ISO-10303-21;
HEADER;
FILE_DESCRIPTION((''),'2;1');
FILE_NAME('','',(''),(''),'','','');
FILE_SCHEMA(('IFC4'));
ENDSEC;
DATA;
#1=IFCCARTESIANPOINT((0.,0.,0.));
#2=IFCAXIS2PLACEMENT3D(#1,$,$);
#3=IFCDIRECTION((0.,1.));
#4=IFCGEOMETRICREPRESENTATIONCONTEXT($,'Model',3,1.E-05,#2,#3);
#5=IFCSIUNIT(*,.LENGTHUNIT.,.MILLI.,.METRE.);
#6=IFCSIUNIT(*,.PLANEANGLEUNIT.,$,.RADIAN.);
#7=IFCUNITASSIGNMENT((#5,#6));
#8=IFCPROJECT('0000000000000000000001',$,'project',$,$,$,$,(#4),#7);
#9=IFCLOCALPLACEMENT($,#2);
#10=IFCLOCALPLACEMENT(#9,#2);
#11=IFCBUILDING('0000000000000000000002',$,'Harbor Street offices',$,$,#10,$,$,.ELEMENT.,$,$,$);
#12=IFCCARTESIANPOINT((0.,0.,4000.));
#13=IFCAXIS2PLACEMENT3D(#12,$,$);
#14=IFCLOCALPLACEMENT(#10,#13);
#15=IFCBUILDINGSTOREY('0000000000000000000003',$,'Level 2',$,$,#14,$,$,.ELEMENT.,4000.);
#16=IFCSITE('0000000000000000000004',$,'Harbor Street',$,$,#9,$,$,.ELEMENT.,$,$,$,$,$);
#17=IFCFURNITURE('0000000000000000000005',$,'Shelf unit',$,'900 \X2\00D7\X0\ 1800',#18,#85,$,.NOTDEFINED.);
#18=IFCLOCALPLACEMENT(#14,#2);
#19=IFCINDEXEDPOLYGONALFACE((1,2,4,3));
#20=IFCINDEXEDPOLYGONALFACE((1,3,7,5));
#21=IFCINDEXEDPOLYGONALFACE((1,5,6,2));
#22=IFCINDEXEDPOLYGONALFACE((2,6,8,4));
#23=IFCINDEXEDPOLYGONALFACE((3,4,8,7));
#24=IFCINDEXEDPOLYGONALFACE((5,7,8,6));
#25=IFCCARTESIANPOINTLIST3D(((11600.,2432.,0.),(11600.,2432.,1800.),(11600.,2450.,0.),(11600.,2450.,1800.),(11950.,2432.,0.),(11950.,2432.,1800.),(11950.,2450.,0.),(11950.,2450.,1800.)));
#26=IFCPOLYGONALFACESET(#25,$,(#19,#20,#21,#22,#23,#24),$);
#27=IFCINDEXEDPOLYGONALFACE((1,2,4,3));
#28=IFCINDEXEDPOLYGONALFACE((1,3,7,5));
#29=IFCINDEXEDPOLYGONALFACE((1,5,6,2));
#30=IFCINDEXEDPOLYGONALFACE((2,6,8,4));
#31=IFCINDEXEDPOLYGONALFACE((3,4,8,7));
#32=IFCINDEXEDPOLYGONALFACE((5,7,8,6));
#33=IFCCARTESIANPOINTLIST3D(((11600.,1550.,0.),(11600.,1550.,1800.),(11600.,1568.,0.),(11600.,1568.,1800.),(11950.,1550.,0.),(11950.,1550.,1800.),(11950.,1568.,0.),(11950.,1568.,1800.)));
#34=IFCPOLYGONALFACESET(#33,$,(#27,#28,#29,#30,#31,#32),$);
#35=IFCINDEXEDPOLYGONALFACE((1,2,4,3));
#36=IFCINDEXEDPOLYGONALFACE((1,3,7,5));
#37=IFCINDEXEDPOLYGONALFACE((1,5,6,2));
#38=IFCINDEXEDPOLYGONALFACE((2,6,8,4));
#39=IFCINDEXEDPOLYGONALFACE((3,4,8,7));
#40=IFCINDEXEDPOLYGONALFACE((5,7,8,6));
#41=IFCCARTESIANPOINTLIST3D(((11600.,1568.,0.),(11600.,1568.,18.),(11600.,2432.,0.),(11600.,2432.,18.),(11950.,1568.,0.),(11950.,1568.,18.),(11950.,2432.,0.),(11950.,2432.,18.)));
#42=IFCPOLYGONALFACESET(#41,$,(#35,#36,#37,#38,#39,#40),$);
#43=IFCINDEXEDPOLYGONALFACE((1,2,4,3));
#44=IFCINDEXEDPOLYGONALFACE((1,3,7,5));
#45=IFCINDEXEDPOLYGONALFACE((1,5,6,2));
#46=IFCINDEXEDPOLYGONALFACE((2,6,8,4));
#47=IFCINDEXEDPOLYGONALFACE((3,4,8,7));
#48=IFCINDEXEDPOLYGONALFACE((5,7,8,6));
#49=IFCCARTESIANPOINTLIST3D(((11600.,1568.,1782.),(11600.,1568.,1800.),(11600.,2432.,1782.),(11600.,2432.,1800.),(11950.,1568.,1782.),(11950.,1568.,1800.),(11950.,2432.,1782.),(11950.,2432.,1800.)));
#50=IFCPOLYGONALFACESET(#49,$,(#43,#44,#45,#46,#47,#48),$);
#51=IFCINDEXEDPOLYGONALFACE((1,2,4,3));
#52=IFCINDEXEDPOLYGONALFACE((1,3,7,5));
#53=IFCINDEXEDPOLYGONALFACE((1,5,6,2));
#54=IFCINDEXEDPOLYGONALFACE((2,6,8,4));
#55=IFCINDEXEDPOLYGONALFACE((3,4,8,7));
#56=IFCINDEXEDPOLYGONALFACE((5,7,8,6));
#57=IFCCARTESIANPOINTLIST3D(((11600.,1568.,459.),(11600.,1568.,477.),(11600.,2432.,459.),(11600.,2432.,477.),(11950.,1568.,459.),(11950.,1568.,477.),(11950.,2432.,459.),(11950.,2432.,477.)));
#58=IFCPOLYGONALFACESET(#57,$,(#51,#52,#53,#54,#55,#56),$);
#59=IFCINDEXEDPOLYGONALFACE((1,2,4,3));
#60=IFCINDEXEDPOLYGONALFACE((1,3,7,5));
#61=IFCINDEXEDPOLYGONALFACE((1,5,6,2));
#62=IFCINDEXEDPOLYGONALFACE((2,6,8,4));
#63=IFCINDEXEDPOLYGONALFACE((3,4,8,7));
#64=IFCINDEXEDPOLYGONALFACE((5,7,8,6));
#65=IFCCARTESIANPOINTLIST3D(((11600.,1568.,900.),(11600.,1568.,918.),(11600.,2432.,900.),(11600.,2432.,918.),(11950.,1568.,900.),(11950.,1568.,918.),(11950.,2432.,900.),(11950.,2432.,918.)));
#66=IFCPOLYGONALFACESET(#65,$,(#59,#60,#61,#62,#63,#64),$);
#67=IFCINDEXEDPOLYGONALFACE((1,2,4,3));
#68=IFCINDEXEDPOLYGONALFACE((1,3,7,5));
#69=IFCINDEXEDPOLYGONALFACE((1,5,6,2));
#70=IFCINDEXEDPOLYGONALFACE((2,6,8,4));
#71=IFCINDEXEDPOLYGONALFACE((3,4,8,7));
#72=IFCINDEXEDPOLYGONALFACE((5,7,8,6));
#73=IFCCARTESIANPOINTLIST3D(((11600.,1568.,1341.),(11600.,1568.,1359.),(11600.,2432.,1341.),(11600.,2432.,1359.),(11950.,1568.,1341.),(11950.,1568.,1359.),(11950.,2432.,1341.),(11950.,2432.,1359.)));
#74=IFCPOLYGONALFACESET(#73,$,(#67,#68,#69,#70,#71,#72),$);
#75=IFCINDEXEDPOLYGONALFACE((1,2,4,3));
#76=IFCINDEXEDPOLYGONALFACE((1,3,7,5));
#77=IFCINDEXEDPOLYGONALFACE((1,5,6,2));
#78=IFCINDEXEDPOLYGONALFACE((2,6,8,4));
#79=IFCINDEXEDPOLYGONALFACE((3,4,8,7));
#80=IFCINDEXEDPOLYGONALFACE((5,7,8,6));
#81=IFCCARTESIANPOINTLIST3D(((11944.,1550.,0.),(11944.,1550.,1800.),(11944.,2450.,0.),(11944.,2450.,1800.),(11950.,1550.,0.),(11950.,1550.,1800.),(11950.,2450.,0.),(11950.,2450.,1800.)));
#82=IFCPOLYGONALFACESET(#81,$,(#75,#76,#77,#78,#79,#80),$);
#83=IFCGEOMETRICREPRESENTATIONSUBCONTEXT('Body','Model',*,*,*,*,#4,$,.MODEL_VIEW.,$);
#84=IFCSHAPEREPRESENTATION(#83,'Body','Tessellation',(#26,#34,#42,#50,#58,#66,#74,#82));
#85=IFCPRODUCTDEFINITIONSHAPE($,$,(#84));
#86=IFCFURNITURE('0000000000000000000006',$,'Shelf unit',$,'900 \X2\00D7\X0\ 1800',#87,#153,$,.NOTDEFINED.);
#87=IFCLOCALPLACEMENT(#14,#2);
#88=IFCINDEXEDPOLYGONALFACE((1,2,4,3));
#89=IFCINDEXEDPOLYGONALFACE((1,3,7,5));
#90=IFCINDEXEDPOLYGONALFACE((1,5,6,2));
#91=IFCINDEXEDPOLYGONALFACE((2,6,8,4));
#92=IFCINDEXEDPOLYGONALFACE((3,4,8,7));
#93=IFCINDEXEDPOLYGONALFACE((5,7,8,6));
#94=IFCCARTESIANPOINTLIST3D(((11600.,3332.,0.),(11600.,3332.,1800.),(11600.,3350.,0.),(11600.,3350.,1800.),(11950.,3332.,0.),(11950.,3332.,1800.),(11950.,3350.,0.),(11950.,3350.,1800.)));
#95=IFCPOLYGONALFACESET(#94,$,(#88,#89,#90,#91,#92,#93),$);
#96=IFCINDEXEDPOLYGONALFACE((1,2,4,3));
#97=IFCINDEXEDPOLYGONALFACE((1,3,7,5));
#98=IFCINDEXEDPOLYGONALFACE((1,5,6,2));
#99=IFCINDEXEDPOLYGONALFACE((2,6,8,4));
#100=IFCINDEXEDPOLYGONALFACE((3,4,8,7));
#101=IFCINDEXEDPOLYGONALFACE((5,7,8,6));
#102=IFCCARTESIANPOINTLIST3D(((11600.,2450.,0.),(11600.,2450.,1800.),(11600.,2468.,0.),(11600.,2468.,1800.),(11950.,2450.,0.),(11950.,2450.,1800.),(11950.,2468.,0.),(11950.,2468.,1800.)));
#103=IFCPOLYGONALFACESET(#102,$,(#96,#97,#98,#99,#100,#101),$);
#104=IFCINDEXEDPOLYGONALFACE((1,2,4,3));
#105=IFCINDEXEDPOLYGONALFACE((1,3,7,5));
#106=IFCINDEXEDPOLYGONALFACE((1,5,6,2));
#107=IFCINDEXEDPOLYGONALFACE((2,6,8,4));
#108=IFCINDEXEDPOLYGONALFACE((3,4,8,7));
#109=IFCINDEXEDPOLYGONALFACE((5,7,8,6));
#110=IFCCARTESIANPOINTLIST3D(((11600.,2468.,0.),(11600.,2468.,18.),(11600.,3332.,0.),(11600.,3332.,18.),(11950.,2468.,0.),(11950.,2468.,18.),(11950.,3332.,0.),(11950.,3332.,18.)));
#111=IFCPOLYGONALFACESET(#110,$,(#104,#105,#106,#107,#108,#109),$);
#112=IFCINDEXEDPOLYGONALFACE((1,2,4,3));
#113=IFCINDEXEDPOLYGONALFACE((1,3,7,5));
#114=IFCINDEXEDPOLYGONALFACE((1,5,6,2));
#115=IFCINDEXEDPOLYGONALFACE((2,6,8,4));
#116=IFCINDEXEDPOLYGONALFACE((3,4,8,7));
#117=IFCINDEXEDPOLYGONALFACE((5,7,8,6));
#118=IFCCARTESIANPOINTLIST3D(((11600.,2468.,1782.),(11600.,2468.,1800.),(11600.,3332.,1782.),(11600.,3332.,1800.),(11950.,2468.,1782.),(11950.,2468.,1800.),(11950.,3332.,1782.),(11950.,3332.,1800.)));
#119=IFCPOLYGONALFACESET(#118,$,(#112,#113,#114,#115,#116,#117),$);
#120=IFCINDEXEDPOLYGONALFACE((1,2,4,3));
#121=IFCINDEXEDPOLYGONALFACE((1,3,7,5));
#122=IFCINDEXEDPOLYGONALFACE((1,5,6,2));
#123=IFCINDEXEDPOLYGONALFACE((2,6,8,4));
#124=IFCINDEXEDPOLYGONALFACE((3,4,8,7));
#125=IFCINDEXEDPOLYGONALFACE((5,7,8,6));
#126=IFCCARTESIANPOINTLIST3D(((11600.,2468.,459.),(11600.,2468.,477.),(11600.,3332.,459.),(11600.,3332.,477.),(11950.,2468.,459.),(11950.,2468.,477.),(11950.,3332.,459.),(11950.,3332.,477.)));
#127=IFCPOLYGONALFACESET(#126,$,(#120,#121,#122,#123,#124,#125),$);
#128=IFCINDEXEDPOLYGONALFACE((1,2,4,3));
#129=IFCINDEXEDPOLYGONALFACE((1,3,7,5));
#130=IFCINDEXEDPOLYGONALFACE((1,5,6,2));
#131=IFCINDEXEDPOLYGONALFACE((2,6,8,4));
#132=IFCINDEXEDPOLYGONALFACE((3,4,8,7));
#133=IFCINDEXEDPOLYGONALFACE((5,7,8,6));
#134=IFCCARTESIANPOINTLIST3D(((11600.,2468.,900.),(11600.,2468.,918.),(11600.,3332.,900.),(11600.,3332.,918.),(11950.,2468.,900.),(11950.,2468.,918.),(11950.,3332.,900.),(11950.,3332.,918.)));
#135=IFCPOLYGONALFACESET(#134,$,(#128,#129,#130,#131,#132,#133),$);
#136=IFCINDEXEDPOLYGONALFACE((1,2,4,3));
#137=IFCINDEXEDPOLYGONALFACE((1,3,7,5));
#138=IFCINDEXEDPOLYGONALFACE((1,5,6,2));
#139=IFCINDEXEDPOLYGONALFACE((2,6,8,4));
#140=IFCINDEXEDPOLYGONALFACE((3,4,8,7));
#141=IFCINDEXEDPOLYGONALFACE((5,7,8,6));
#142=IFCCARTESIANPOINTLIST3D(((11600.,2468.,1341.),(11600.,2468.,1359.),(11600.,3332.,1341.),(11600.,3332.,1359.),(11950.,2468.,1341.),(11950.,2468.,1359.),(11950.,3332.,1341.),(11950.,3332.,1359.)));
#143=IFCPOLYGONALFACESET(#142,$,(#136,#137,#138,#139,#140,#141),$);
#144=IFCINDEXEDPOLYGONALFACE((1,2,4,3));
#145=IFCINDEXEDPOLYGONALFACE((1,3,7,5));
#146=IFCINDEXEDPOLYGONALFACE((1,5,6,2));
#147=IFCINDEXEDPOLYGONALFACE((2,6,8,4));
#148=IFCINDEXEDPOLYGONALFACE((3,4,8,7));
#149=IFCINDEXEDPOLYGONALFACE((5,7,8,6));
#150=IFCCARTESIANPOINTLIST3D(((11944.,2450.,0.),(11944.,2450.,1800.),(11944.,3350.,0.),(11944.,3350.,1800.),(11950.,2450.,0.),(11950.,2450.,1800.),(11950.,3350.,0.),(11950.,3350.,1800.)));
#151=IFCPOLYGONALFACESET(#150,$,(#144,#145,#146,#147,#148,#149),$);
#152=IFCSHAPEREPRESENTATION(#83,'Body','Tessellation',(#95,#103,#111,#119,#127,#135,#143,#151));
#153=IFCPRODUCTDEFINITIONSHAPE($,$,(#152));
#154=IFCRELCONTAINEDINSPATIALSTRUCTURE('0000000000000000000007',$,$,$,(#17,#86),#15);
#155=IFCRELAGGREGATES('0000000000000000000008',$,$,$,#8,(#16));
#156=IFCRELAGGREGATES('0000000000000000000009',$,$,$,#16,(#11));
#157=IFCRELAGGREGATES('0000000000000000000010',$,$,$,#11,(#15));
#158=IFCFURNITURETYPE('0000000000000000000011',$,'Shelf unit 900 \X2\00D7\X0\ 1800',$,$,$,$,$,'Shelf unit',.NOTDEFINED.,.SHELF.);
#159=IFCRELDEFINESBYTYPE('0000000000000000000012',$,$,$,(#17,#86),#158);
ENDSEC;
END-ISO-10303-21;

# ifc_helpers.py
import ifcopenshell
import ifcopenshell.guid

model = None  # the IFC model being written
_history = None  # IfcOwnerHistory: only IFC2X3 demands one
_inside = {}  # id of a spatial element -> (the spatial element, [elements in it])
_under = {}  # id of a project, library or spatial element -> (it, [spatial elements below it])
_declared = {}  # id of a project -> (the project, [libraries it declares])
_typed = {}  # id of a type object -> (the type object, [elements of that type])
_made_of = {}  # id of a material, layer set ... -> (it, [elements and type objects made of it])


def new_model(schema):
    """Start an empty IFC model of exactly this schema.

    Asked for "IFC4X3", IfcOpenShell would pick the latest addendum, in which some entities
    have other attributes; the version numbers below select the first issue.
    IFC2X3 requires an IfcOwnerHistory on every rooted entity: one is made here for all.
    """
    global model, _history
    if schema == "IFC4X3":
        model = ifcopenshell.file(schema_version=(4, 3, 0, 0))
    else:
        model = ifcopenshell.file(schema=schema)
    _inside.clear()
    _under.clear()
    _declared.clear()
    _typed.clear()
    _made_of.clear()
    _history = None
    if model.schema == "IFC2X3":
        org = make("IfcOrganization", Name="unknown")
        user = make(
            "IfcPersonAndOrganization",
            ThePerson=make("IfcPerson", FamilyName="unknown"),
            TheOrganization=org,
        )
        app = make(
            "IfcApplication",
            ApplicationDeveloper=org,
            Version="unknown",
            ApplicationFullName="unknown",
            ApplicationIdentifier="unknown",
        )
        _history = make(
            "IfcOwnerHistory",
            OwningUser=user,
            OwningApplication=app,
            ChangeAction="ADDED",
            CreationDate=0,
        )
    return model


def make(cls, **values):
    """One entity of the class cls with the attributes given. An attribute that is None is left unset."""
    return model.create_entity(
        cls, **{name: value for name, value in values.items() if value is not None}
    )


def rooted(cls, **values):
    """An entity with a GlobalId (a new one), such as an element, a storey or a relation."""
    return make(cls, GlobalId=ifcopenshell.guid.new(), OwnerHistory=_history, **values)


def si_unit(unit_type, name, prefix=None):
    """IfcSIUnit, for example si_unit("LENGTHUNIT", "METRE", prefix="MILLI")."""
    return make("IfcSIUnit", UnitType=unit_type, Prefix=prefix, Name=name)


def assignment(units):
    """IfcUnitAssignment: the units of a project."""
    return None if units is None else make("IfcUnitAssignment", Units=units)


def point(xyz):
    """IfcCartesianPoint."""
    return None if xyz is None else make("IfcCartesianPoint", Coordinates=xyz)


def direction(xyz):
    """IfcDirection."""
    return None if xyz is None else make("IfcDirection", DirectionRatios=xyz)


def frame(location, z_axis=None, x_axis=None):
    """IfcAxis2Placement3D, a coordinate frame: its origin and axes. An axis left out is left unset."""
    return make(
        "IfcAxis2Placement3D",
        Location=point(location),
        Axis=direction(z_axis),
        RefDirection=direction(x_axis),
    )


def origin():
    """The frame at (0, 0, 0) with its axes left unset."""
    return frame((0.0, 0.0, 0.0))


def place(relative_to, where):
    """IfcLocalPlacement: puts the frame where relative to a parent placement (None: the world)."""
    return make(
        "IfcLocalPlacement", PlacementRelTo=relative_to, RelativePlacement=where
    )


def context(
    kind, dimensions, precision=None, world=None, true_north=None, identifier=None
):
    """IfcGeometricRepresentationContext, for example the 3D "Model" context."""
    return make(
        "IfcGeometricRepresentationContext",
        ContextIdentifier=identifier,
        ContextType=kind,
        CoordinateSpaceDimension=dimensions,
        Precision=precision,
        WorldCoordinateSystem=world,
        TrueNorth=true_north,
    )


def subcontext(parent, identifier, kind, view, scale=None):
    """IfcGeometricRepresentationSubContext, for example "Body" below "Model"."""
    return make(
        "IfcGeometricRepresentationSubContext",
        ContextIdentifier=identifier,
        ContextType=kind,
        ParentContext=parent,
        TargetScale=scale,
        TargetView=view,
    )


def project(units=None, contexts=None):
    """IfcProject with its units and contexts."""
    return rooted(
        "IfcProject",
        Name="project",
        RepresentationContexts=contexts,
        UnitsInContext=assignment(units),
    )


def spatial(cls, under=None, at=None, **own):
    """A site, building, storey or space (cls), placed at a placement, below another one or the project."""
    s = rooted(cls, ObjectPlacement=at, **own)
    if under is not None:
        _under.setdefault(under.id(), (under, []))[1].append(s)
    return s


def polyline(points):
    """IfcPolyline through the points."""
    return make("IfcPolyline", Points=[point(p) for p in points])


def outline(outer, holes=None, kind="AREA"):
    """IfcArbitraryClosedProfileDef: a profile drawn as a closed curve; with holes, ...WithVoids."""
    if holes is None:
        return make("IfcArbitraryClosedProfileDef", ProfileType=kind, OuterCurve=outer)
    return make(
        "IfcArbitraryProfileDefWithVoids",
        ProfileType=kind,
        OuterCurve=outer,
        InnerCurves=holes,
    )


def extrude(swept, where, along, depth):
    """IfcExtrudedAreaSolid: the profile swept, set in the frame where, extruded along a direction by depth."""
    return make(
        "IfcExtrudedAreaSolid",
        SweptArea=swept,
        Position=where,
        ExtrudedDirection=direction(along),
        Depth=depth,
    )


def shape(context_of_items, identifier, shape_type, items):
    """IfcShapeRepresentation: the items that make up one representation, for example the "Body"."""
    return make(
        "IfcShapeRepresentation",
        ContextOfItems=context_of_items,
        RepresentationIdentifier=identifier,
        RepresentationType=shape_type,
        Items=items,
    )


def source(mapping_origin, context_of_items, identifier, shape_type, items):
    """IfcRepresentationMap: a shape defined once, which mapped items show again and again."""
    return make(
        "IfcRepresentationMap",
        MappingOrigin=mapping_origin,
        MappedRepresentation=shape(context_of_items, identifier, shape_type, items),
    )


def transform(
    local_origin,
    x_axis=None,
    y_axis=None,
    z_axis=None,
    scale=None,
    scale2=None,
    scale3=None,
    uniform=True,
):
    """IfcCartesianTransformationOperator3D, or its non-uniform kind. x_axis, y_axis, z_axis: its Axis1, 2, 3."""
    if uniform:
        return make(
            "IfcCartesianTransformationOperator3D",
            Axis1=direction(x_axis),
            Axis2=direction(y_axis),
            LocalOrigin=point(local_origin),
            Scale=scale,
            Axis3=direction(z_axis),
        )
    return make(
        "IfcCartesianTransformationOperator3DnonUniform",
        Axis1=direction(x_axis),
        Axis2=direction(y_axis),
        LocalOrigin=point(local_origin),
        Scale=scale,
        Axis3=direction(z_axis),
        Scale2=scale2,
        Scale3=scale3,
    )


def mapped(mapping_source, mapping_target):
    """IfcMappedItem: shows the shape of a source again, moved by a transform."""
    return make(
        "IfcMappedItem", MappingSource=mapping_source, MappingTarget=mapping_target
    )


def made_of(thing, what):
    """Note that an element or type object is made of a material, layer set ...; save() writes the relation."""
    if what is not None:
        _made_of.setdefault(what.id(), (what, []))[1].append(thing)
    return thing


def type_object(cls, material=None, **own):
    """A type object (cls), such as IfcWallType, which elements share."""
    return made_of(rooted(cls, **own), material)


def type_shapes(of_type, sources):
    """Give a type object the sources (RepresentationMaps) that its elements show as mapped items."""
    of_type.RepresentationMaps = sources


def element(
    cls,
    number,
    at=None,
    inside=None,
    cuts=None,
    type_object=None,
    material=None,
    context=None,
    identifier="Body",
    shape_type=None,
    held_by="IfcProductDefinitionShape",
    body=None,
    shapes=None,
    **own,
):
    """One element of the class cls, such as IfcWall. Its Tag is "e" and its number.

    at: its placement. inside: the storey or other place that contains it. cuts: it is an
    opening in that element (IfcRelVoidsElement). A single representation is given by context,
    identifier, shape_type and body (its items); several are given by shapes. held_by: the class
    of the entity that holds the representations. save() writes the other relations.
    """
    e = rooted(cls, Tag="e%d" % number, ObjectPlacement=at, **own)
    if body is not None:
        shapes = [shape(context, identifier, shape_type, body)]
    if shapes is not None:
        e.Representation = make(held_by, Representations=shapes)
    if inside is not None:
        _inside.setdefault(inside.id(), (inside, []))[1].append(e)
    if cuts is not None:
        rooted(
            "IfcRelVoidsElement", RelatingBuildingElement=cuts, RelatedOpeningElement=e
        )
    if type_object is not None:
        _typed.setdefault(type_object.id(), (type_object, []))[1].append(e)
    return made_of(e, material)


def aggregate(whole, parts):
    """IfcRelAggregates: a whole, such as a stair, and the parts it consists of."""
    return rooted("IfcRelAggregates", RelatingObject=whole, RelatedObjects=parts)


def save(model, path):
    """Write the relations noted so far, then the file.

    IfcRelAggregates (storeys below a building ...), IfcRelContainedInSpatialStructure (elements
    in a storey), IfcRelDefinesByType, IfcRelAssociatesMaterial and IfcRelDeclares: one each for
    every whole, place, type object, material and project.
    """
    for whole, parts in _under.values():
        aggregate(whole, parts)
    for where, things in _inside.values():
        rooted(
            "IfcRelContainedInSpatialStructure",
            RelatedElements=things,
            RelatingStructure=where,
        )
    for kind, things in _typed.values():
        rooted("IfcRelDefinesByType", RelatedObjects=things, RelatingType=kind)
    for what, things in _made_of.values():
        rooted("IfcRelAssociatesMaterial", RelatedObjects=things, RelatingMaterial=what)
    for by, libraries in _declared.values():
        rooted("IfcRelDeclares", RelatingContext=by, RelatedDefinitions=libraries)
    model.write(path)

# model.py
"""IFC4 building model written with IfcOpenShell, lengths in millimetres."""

from ifc_helpers import new_model, si_unit, direction, frame, origin, place, context, subcontext, project, spatial, polyline, outline, extrude, source, transform, mapped, type_object, type_shapes, element, save


model = new_model("IFC4")

# Units and contexts
model_context = context("Model", 3, precision=1e-05, world=origin(), true_north=direction((0.0, 1.0)))
body_context = subcontext(model_context, "Body", "Model", "MODEL_VIEW")
ifc_project = project(units=[si_unit("LENGTHUNIT", "METRE", prefix="MILLI"), si_unit("PLANEANGLEUNIT", "RADIAN")], contexts=[model_context])

# Site, building, storey
site_placement = place(None, origin())
site = spatial("IfcSite", under=ifc_project, at=site_placement, Name="Harbor Street", CompositionType="ELEMENT")
building_placement = place(site_placement, origin())
building = spatial("IfcBuilding", under=site, at=building_placement, Name="Harbor Street offices", CompositionType="ELEMENT")
storey_placement = place(building_placement, frame((0.0, 0.0, 4000.0)))
storey = spatial("IfcBuildingStorey", under=building, at=storey_placement, Name="Level 2", CompositionType="ELEMENT", Elevation=4000.0)

# Furniture
furniture_type_1 = type_object("IfcFurnitureType", Name="Shelf unit 900 × 1800", ElementType="Shelf unit", AssemblyPlace="NOTDEFINED", PredefinedType="SHELF")
shared_shape_1 = source(origin(), body_context, "Body", "SweptSolid", [
    extrude(outline(polyline([(-450.0, 0.0), (-432.0, 0.0), (-432.0, 350.0), (-450.0, 350.0), (-450.0, 0.0)])), origin(), (0.0, 0.0, 1.0), 1800.0),
    extrude(outline(polyline([(432.0, 0.0), (450.0, 0.0), (450.0, 350.0), (432.0, 350.0), (432.0, 0.0)])), origin(), (0.0, 0.0, 1.0), 1800.0),
    extrude(outline(polyline([(-432.0, 0.0), (432.0, 0.0), (432.0, 350.0), (-432.0, 350.0), (-432.0, 0.0)])), origin(), (0.0, 0.0, 1.0), 18.0),
    extrude(outline(polyline([(-432.0, 0.0), (432.0, 0.0), (432.0, 350.0), (-432.0, 350.0), (-432.0, 0.0)])), frame((0.0, 0.0, 1782.0)), (0.0, 0.0, 1.0), 18.0),
    extrude(outline(polyline([(-432.0, 0.0), (432.0, 0.0), (432.0, 350.0), (-432.0, 350.0), (-432.0, 0.0)])), frame((0.0, 0.0, 459.0)), (0.0, 0.0, 1.0), 18.0),
    extrude(outline(polyline([(-432.0, 0.0), (432.0, 0.0), (432.0, 350.0), (-432.0, 350.0), (-432.0, 0.0)])), frame((0.0, 0.0, 900.0)), (0.0, 0.0, 1.0), 18.0),
    extrude(outline(polyline([(-432.0, 0.0), (432.0, 0.0), (432.0, 350.0), (-432.0, 350.0), (-432.0, 0.0)])), frame((0.0, 0.0, 1341.0)), (0.0, 0.0, 1.0), 18.0),
    extrude(outline(polyline([(-450.0, 344.0), (450.0, 344.0), (450.0, 350.0), (-450.0, 350.0), (-450.0, 344.0)])), origin(), (0.0, 0.0, 1.0), 1800.0),
])
type_shapes(furniture_type_1, [shared_shape_1])
for number, where, z_axis, x_axis, name in (
    (1, (11600.0, 2000.0, 0.0), (0.0, 0.0, 1.0), (0.0, -1.0, 0.0), "Shelf unit"),
    (2, (11600.0, 2900.0, 0.0), (0.0, 0.0, 1.0), (0.0, -1.0, 0.0), "Shelf unit"),
):
    element("IfcFurniture", number, at=place(storey_placement, frame(where, z_axis=z_axis, x_axis=x_axis)), inside=storey, type_object=furniture_type_1, Name=name, ObjectType="900 × 1800", PredefinedType="NOTDEFINED", context=body_context, shape_type="MappedRepresentation", body=[
        mapped(shared_shape_1, transform((0.0, 0.0, 0.0))),
    ])

save(model, "model.ifc")
